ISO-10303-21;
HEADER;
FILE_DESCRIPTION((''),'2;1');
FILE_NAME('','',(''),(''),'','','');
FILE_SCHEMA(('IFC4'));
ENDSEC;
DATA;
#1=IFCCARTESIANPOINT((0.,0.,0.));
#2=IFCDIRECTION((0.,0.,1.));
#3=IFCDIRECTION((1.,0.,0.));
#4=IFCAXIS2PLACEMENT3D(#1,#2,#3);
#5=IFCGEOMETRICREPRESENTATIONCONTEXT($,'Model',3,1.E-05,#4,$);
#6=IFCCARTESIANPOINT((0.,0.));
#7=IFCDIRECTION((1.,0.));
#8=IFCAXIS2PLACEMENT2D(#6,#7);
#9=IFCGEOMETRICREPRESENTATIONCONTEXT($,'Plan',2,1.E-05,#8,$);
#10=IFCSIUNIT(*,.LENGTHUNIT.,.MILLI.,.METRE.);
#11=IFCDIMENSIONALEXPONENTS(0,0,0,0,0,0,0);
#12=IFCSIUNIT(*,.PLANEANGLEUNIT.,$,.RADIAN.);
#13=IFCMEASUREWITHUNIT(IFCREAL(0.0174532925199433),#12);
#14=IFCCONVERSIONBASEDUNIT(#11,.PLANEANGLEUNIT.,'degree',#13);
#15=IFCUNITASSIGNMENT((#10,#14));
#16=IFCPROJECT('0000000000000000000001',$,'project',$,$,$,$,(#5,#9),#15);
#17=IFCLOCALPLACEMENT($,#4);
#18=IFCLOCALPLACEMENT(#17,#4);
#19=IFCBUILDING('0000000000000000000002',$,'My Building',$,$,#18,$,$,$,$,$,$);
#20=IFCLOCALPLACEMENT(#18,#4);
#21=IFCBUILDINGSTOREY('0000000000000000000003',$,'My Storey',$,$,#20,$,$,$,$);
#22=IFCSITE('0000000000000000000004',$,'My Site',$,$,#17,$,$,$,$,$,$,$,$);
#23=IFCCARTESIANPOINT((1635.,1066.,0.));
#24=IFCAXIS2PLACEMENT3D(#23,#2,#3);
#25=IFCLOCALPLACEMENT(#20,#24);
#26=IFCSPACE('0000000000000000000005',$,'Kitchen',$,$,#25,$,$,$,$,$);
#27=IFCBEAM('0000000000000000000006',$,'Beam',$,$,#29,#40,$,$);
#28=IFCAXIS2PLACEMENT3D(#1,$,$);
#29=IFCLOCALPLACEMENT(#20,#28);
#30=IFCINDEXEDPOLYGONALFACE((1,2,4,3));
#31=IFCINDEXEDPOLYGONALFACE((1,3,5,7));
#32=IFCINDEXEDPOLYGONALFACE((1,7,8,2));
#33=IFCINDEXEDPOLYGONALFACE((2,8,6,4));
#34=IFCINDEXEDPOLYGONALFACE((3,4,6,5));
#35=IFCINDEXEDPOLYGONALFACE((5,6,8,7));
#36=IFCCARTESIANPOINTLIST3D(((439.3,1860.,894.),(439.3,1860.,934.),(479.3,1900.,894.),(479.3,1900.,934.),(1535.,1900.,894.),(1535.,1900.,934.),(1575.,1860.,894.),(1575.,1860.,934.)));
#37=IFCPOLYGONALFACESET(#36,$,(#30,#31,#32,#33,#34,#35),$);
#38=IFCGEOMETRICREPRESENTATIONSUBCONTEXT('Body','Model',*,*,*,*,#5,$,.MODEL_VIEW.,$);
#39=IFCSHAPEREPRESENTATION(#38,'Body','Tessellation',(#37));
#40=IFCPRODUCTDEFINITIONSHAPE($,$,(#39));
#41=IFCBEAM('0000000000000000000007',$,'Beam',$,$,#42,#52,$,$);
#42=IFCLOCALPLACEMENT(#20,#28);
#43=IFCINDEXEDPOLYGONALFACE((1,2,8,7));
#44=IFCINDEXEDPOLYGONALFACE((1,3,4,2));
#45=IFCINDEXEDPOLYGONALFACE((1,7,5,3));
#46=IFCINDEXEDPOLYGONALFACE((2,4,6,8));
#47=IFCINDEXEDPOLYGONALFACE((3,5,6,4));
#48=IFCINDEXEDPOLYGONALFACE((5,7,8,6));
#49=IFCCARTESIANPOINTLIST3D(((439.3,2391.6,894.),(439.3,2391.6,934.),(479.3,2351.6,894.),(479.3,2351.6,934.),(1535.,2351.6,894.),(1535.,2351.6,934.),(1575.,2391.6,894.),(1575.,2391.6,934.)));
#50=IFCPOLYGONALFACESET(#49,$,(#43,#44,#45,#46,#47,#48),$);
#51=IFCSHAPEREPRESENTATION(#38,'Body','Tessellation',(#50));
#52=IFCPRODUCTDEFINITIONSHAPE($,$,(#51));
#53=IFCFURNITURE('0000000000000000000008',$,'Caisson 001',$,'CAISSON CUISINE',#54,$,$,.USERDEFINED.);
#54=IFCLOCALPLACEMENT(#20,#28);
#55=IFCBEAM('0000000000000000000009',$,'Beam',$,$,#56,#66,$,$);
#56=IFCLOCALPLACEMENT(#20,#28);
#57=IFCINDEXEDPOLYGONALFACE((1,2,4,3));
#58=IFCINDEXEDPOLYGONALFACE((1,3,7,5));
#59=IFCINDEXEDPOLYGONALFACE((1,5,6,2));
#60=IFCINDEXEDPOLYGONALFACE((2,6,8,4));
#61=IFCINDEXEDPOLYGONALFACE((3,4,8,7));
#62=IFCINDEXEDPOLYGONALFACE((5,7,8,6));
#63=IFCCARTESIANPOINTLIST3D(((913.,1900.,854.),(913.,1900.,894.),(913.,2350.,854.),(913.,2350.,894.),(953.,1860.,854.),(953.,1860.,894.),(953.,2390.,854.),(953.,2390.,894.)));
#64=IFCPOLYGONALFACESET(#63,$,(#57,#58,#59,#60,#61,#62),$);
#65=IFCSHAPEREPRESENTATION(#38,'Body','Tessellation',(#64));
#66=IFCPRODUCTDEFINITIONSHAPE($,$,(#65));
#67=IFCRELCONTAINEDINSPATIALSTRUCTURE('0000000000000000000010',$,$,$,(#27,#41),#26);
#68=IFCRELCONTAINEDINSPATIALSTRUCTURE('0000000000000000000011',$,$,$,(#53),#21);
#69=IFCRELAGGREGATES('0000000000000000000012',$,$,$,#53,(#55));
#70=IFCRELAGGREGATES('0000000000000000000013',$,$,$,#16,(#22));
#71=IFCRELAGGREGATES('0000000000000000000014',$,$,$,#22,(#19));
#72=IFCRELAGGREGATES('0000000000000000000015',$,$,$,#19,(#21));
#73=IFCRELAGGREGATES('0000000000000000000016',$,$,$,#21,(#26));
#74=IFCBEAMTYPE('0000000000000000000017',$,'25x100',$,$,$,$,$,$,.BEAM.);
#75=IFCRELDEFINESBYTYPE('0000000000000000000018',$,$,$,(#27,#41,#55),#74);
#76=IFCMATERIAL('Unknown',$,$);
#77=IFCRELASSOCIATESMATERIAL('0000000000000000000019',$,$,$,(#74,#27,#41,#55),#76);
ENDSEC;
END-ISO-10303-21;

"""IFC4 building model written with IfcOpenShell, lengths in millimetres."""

from ifc_helpers import new_model, entity, si_unit, converted_unit, frame, origin_with_axes, origin_2d_with_axis, place, context, subcontext, project, spatial, rectangle, extrude, clip, halfspace, material, material_profile, profile_set, profile_usage, type_object, element, aggregate, save


model = new_model("IFC4")

# Units and contexts
model_context = context("Model", 3, precision=1e-05, world=origin_with_axes())
plan_context = context("Plan", 2, precision=1e-05, world=origin_2d_with_axis())
body_context = subcontext(model_context, "Body", "Model", "MODEL_VIEW")
ifc_project = project(units=[si_unit("LENGTHUNIT", "METRE", prefix="MILLI"), converted_unit("PLANEANGLEUNIT", "degree", entity("IfcReal", 0.0174532925199433), si_unit("PLANEANGLEUNIT", "RADIAN"), dimensions=[0, 0, 0, 0, 0, 0, 0])], contexts=[model_context, plan_context])

# Site, building, storey, space
site_placement = place(None, origin_with_axes())
site = spatial("IfcSite", under=ifc_project, at=site_placement, Name="My Site")
building_placement = place(site_placement, origin_with_axes())
building = spatial("IfcBuilding", under=site, at=building_placement, Name="My Building")
storey_placement = place(building_placement, origin_with_axes())
storey = spatial("IfcBuildingStorey", under=building, at=storey_placement, Name="My Storey")
space_1_placement = place(storey_placement, frame((1635.0, 1066.0, 0.0), z_axis=(0.0, 0.0, 1.0), x_axis=(1.0, 0.0, 0.0)))
space_1 = spatial("IfcSpace", under=storey, at=space_1_placement, Name="Kitchen")

# Beams
ifc_material_1 = material(Name="Unknown")
ifc_material_profile = material_profile(ifc_material_1, rectangle(XDim=40.0, YDim=40.0))
ifc_profile_set = profile_set([ifc_material_profile])
ifc_profile_usage_1 = profile_usage(ifc_profile_set)
beam_type = type_object("IfcBeamType", Name="25x100", PredefinedType="BEAM", material=ifc_profile_set)
beam_1_placement = place(space_1_placement, frame((-1195.7, 814.0, 914.0), z_axis=(1.0, 0.0, 0.0), x_axis=(0.0, 1.0, 0.0)))
element("IfcBeam", 1, at=beam_1_placement, inside=space_1, type_object=beam_type, material=ifc_profile_usage_1, Name="Beam", context=body_context, shape_type="Clipping", body=[
    clip(clip(extrude(rectangle(XDim=40.0, YDim=40.0), origin_with_axes(), (0.0, 0.0, 1.0), 1135.7), halfspace(frame((-20.0, -914.0, 0.0), z_axis=(0.707106, 0.0, -0.707107), x_axis=(0.0, -1.0, 0.0)), False)), halfspace(frame((-20.0, -914.0, 1135.7), z_axis=(0.707115, 0.0, 0.707098), x_axis=(0.0, -1.0, 0.0)), False)),
])
ifc_profile_usage_2 = profile_usage(ifc_profile_set)
beam_2_placement = place(space_1_placement, frame((-1195.7, 1305.6, 914.0), z_axis=(1.0, 0.0, 0.0), x_axis=(0.0, 1.0, 0.0)))
element("IfcBeam", 2, at=beam_2_placement, inside=space_1, type_object=beam_type, material=ifc_profile_usage_2, Name="Beam", context=body_context, shape_type="Clipping", body=[
    clip(clip(extrude(rectangle(XDim=40.0, YDim=40.0), origin_with_axes(), (0.0, 0.0, 1.0), 1135.7), halfspace(frame((20.0, -914.0, 1135.7), z_axis=(-0.707115, 0.0, 0.707099), x_axis=(0.0, 1.0, 0.0)), False)), halfspace(frame((20.0, -914.0, 0.0), z_axis=(-0.707107, 0.0, -0.707106), x_axis=(0.0, 1.0, 0.0)), False)),
])

# Furniture, beam
furniture_1_placement = place(storey_placement, frame((990.2, 1853.1, 20.0), z_axis=(0.0, 0.0, 1.0), x_axis=(1.0, 0.0, 0.0)))
furniture_1 = element("IfcFurniture", 3, at=furniture_1_placement, inside=storey, Name="Caisson 001", ObjectType="CAISSON CUISINE", PredefinedType="USERDEFINED")
ifc_profile_usage_3 = profile_usage(ifc_profile_set, cardinal=5)
beam_3_placement = place(furniture_1_placement, frame((-57.2, 6.9, 854.0), z_axis=(0.000001, 1.0, 0.0), x_axis=(-1.0, 0.000001, 0.0)))
beam_3 = element("IfcBeam", 4, at=beam_3_placement, type_object=beam_type, material=ifc_profile_usage_3, Name="Beam", context=body_context, shape_type="Clipping", body=[
    clip(clip(extrude(rectangle(XDim=40.0, YDim=40.0), origin_with_axes(), (0.0, 0.0, 1.0), 530.0), halfspace(frame((-20.0, -874.0, 530.0), z_axis=(0.707107, 0.0, 0.707106), x_axis=(0.0, -1.0, 0.0)), False)), halfspace(frame((-20.0, -874.0, 0.0), z_axis=(0.707111, 0.0, -0.707103), x_axis=(0.0, -1.0, 0.0)), False)),
])

aggregate(furniture_1, [beam_3])

save(model, "model.ifc")
